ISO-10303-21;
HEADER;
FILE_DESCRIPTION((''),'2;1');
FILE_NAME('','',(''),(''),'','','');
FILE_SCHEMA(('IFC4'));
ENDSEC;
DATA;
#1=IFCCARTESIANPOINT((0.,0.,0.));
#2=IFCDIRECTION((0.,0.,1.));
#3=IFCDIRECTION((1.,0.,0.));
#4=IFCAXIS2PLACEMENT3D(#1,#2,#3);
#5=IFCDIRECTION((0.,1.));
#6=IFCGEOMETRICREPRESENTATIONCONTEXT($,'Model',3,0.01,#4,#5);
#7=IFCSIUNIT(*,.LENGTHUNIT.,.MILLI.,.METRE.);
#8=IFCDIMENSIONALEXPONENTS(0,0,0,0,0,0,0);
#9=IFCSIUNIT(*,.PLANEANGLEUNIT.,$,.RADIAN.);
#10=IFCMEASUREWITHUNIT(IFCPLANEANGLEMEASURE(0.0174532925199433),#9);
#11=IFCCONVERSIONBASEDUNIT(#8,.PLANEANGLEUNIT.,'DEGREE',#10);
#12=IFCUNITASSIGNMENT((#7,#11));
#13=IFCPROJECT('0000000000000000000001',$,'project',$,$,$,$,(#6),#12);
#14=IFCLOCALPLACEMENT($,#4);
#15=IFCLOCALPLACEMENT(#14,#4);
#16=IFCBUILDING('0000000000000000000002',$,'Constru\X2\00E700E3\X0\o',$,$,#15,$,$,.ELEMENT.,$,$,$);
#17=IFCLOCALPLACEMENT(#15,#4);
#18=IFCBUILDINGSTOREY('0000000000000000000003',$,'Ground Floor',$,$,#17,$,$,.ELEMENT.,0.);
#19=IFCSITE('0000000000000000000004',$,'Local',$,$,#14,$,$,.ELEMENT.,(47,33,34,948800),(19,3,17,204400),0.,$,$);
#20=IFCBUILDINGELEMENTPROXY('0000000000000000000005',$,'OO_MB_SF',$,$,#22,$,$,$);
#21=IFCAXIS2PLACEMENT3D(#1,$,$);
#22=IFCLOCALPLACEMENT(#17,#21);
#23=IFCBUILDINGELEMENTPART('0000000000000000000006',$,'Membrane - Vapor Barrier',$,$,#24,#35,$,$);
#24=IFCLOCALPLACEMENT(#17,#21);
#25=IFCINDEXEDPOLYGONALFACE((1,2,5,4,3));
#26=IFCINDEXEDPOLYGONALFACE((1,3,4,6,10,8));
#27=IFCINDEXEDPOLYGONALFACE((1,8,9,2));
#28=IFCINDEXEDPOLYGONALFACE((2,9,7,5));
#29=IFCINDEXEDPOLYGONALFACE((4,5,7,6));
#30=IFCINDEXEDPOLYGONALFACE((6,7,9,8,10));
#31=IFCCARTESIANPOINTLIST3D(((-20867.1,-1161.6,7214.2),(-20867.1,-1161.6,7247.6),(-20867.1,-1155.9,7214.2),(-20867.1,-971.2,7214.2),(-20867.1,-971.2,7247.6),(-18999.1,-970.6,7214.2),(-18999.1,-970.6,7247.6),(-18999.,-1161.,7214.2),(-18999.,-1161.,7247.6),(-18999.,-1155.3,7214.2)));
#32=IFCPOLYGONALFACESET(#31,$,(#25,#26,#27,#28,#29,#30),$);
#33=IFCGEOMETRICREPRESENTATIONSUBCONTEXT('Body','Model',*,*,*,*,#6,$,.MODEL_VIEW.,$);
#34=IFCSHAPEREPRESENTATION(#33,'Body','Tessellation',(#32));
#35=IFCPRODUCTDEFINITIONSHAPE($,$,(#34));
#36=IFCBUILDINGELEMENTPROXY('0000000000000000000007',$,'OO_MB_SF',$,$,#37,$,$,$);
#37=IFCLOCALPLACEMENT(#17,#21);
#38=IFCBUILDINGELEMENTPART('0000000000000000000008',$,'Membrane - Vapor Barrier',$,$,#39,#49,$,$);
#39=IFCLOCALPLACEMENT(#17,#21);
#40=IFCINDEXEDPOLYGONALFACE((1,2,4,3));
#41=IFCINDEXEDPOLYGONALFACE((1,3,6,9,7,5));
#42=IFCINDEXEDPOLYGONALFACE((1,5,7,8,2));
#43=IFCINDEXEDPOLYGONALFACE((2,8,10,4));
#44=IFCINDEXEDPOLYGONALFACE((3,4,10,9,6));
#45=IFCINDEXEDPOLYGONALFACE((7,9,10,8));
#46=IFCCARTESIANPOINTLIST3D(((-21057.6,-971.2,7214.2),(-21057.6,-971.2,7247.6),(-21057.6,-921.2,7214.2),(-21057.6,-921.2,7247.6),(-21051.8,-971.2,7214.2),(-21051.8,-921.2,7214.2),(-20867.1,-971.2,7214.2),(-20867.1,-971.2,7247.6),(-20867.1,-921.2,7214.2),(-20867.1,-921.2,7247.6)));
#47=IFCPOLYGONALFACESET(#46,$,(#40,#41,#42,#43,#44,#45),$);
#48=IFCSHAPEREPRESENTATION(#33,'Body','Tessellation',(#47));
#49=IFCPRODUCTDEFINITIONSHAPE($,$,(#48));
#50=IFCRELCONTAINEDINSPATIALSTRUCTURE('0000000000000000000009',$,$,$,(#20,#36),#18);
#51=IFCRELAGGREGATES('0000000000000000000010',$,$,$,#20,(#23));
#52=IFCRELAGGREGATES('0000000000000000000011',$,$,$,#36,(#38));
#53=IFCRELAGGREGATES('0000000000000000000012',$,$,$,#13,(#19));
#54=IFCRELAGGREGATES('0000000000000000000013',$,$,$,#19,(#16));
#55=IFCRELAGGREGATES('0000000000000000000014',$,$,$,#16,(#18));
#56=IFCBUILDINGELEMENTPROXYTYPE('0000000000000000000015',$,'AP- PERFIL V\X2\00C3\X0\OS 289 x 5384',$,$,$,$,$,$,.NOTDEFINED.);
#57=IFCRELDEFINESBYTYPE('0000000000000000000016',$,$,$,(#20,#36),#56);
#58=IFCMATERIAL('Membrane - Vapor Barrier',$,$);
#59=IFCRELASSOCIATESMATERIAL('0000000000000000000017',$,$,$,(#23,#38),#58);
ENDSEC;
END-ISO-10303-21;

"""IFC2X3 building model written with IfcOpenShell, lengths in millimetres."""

from ifc_helpers import new_model, entity, si_unit, converted_unit, direction, frame, origin_with_axes, place, context, subcontext, project, spatial, polyline, outline, extrude, material, type_object, element, aggregate, save


model = new_model("IFC2X3")

# Units and contexts
model_context = context("Model", 3, precision=0.01, world=origin_with_axes(), true_north=direction((0.0, 1.0)))
body_context = subcontext(model_context, "Body", "Model", "MODEL_VIEW")
ifc_project = project(units=[si_unit("LENGTHUNIT", "METRE", prefix="MILLI"), converted_unit("PLANEANGLEUNIT", "DEGREE", entity("IfcPlaneAngleMeasure", 0.0174532925199433), si_unit("PLANEANGLEUNIT", "RADIAN"), dimensions=[0, 0, 0, 0, 0, 0, 0])], contexts=[model_context])

# Site, building, storey
site_placement = place(None, origin_with_axes())
site = spatial("IfcSite", under=ifc_project, at=site_placement, Name="Local", CompositionType="ELEMENT", RefLatitude=(47, 33, 34, 948800), RefLongitude=(19, 3, 17, 204400), RefElevation=0.0)
building_placement = place(site_placement, origin_with_axes())
building = spatial("IfcBuilding", under=site, at=building_placement, Name="Construção", CompositionType="ELEMENT")
storey_placement = place(building_placement, origin_with_axes())
storey = spatial("IfcBuildingStorey", under=building, at=storey_placement, Name="Ground Floor", CompositionType="ELEMENT", Elevation=0.0)

# Building element proxies, building element parts
building_element_proxy_type = type_object("IfcBuildingElementProxyType", Name="AP- PERFIL VÃOS 289 x 5384", PredefinedType="NOTDEFINED")
ifc_material = material(Name="Membrane - Vapor Barrier")
proxy_1_placement = place(storey_placement, frame((-20867.1, -971.2, 7247.6), z_axis=(0.0, 0.0, 1.0), x_axis=(0.000322, -1.0, 0.0)))
proxy_1 = element("IfcBuildingElementProxy", 1, at=proxy_1_placement, inside=storey, type_object=building_element_proxy_type, Name="OO_MB_SF")
building_element_part_1_placement = place(proxy_1_placement, origin_with_axes())
building_element_part_1 = element("IfcBuildingElementPart", 2, at=building_element_part_1_placement, material=ifc_material, Name="Membrane - Vapor Barrier", context=body_context, shape_type="SweptSolid", body=[
    extrude(outline(polyline([(190.4, 0.0), (0.0, 0.0), (0.0, -33.3), (184.7, -33.3), (190.4, -33.3), (190.4, 0.0)])), frame((0.0, 1868.0, 0.0), z_axis=(0.0, -1.0, 0.0), x_axis=(1.0, 0.0, 0.0)), (0.0, 0.0, 1.0), 1868.0),
])
aggregate(proxy_1, [building_element_part_1])
proxy_2_placement = place(storey_placement, frame((-20867.1, -921.2, 7247.6), z_axis=(0.0, 0.0, 1.0), x_axis=(-1.0, -0.000322, 0.0)))
proxy_2 = element("IfcBuildingElementProxy", 3, at=proxy_2_placement, inside=storey, type_object=building_element_proxy_type, Name="OO_MB_SF")
building_element_part_2_placement = place(proxy_2_placement, origin_with_axes())
building_element_part_2 = element("IfcBuildingElementPart", 4, at=building_element_part_2_placement, material=ifc_material, Name="Membrane - Vapor Barrier", context=body_context, shape_type="SweptSolid", body=[
    extrude(outline(polyline([(190.4, 0.0), (0.0, 0.0), (0.0, -33.3), (184.7, -33.3), (190.4, -33.3), (190.4, 0.0)])), frame((0.0, 50.0, 0.0), z_axis=(0.0, -1.0, 0.0), x_axis=(1.0, 0.0, 0.0)), (0.0, 0.0, 1.0), 50.0),
])
aggregate(proxy_2, [building_element_part_2])

save(model, "model.ifc")
